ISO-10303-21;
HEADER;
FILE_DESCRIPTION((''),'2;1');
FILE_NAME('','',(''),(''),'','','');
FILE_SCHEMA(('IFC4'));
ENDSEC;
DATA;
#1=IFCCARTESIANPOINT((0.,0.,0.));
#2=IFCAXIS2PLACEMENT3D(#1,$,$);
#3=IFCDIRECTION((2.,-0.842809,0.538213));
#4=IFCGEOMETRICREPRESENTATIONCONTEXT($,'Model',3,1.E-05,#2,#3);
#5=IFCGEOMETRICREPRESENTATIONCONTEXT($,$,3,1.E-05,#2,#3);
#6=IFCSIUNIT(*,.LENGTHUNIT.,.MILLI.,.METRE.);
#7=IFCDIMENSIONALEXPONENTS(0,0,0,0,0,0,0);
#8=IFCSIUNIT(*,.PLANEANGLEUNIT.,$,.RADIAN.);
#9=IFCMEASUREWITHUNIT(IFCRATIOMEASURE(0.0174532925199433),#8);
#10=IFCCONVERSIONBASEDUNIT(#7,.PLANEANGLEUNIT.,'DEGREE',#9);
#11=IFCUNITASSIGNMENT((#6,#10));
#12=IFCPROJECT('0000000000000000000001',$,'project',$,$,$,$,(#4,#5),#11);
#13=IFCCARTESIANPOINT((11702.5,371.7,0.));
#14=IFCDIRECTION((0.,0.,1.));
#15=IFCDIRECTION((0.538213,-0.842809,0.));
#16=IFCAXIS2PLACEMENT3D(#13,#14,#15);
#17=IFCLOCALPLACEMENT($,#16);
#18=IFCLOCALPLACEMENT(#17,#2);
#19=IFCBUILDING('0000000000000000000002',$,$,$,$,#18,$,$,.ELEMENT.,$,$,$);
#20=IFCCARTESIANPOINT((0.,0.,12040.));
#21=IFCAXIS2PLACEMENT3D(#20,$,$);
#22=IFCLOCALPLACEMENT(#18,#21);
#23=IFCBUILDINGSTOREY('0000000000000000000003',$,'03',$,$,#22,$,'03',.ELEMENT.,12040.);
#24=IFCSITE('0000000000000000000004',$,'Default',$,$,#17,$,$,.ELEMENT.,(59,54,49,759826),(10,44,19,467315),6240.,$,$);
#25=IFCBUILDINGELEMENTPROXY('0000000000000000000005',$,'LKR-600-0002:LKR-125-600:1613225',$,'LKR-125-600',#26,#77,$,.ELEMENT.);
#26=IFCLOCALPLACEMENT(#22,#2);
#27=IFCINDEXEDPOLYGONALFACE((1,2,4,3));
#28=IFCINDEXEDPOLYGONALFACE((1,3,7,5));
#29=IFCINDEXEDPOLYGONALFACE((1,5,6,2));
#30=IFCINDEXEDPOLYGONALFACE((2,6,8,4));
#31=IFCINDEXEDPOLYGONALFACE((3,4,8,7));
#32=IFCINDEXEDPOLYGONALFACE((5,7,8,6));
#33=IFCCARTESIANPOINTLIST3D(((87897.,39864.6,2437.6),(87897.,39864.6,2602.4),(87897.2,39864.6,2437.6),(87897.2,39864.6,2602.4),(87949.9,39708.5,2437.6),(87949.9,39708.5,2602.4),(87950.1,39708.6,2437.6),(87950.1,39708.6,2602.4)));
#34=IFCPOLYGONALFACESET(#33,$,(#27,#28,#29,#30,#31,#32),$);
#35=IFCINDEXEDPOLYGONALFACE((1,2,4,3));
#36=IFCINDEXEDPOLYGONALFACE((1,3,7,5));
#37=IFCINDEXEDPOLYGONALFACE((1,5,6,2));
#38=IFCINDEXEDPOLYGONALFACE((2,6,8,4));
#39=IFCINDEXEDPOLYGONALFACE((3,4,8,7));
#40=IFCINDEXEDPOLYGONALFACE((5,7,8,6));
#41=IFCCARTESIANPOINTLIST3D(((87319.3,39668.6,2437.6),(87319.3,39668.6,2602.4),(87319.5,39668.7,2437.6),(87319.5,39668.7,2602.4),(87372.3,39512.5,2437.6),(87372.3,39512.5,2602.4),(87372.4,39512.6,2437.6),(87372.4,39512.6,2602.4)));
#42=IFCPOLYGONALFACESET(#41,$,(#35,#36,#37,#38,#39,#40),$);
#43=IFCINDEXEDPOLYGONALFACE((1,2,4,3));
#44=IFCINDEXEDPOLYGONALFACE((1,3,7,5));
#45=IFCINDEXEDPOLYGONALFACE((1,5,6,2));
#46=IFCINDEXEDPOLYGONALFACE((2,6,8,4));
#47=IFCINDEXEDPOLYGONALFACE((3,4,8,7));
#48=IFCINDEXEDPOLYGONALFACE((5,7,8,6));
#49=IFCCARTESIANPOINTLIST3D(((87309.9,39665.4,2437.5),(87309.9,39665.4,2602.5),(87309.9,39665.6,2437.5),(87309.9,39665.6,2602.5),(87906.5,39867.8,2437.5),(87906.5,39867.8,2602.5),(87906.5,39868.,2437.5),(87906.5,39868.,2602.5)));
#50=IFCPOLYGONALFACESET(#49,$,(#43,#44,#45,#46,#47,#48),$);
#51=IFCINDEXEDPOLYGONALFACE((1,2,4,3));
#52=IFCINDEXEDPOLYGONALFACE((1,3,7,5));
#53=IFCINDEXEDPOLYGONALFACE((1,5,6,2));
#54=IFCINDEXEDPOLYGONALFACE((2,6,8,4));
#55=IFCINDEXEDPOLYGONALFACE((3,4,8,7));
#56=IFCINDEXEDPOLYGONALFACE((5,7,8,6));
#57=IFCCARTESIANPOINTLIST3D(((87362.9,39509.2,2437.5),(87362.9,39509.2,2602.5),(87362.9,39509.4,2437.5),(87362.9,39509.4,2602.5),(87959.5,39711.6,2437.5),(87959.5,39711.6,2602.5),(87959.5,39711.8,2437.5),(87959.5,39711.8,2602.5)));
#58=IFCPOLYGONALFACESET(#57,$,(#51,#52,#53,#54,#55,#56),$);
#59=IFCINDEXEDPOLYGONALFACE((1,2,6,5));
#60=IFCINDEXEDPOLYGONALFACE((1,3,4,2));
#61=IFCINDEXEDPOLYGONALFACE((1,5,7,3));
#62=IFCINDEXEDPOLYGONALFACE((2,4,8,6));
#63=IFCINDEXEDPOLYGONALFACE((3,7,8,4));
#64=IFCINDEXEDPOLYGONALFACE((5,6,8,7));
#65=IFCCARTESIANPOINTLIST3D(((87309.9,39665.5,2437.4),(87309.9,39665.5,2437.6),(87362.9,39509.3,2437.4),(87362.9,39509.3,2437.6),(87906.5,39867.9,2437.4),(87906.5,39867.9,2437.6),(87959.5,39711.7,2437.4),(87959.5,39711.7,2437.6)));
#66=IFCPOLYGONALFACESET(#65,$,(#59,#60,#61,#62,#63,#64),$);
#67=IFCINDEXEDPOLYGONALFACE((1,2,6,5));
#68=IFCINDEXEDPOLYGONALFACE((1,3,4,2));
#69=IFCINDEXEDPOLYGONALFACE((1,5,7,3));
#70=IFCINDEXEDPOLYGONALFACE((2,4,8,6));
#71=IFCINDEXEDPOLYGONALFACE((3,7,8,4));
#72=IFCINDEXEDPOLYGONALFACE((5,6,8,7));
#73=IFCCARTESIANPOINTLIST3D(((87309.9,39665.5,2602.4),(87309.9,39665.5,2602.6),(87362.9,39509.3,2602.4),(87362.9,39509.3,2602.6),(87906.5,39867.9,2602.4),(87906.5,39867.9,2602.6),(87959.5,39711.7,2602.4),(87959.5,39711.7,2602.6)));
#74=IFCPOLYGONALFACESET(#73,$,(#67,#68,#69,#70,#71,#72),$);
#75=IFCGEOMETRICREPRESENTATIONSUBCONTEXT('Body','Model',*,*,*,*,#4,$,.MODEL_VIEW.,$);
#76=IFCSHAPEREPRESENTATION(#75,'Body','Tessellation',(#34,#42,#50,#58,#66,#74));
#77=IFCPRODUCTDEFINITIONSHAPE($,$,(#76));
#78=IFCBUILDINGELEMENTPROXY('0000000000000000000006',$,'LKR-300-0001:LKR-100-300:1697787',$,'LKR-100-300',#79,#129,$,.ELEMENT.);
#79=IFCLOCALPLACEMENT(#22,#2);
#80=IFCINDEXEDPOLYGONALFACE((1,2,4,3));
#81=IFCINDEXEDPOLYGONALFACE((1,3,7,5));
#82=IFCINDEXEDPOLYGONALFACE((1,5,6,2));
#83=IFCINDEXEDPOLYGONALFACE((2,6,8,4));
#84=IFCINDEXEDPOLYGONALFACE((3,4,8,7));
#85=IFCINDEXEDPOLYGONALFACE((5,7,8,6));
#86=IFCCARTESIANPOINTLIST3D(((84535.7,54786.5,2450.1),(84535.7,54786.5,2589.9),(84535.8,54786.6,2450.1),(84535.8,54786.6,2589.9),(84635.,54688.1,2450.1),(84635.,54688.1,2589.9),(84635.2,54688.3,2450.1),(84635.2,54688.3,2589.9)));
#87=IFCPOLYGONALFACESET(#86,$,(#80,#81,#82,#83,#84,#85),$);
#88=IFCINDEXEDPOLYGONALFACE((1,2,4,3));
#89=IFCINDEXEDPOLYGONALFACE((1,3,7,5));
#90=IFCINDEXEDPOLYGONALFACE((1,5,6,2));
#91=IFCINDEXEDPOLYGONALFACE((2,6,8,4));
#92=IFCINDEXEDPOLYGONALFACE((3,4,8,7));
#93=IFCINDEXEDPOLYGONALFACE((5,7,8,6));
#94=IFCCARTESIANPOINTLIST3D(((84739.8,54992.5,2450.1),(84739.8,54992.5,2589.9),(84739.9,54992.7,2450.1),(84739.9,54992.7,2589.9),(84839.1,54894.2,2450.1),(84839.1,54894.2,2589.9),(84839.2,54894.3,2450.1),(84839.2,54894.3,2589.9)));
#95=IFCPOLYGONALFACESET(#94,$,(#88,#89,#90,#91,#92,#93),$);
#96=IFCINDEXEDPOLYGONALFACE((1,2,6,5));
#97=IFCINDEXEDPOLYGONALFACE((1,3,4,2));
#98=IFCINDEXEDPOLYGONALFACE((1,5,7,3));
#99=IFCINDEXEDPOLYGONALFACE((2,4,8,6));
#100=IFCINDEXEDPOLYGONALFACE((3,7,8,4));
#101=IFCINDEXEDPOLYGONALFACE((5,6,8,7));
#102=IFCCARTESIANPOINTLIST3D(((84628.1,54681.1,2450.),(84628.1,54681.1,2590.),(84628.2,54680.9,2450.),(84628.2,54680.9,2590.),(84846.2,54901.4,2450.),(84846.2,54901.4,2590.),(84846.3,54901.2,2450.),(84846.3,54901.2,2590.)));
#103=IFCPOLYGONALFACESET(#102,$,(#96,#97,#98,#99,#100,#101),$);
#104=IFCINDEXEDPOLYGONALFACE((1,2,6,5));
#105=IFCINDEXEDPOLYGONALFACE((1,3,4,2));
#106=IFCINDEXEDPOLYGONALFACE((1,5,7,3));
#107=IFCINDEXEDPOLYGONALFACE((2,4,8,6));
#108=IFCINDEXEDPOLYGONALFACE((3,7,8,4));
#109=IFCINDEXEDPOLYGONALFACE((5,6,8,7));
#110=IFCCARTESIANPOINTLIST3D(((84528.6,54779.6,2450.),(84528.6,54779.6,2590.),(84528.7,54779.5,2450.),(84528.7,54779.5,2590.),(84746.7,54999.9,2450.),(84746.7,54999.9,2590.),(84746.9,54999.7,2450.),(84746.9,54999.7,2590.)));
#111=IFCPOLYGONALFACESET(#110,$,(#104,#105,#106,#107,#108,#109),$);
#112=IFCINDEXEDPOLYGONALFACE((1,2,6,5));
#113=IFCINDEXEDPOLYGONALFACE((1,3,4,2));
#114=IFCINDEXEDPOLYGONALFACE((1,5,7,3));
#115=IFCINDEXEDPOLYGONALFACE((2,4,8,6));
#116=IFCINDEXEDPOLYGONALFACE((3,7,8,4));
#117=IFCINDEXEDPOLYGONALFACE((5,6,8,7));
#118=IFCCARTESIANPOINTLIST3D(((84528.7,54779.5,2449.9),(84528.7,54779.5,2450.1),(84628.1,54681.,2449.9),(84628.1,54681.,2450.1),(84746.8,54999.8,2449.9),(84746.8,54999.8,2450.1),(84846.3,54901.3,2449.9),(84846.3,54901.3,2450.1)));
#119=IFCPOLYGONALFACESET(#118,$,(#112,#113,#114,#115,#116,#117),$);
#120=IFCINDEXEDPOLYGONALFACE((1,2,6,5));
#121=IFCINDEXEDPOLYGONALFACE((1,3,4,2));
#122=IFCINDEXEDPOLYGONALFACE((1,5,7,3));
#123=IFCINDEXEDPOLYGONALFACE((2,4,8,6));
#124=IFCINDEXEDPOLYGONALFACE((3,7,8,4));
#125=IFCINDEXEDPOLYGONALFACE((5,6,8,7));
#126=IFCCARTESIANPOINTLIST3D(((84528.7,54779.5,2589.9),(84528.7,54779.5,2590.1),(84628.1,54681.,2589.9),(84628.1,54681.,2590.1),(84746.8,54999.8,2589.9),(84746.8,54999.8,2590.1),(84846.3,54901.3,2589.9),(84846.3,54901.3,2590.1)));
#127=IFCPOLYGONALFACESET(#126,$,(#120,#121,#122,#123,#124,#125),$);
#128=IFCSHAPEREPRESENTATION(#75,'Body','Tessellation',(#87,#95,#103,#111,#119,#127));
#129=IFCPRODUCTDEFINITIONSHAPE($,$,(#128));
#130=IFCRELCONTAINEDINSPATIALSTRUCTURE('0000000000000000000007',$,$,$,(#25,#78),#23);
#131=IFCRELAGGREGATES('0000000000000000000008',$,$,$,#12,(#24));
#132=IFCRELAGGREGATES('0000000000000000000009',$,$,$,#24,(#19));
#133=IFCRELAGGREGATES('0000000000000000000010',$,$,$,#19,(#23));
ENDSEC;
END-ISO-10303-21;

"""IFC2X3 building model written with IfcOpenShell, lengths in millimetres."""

from ifc_helpers import new_model, entity, si_unit, converted_unit, direction, frame, frame_2d, origin, origin_2d_with_axis, place, context, subcontext, project, spatial, rectangle, extrude, source, transform, mapped, element, save


model = new_model("IFC2X3")

# Units and contexts
model_context = context("Model", 3, precision=1e-05, world=origin(), true_north=direction((2.0, -0.842809, 0.538213)))
context_of_model = context(None, 3, precision=1e-05, world=origin(), true_north=direction((2.0, -0.842809, 0.538213)))
body_context = subcontext(model_context, "Body", "Model", "MODEL_VIEW")
ifc_project = project(units=[si_unit("LENGTHUNIT", "METRE", prefix="MILLI"), converted_unit("PLANEANGLEUNIT", "DEGREE", entity("IfcRatioMeasure", 0.0174532925199433), si_unit("PLANEANGLEUNIT", "RADIAN"), dimensions=[0, 0, 0, 0, 0, 0, 0])], contexts=[model_context, context_of_model])

# Site, building, storey
site_placement = place(None, frame((11702.5, 371.7, 0.0), z_axis=(0.0, 0.0, 1.0), x_axis=(0.538213, -0.842809, 0.0)))
site = spatial("IfcSite", under=ifc_project, at=site_placement, Name="Default", CompositionType="ELEMENT", RefLatitude=(59, 54, 49, 759826), RefLongitude=(10, 44, 19, 467315), RefElevation=6240.0)
building_placement = place(site_placement, origin())
building = spatial("IfcBuilding", under=site, at=building_placement, CompositionType="ELEMENT")
storey_placement = place(building_placement, frame((0.0, 0.0, 12040.0)))
storey = spatial("IfcBuildingStorey", under=building, at=storey_placement, Name="03", LongName="03", CompositionType="ELEMENT", Elevation=12040.0)

# Building element proxies
shared_shape_1 = source(origin(), body_context, "Body", "SweptSolid", [
    extrude(rectangle(XDim=0.2, YDim=164.8, at=frame_2d((0.0, 0.0), x_axis=(1.0, 0.0))), frame((305.0, 0.0, -82.4)), (0.0, 0.0, 1.0), 164.8),
    extrude(rectangle(XDim=0.2, YDim=164.8, at=frame_2d((0.0, 0.0), x_axis=(1.0, 0.0))), frame((-305.0, 0.0, -82.4)), (0.0, 0.0, 1.0), 164.8),
    extrude(rectangle(XDim=0.2, YDim=630.0, at=frame_2d((0.0, 0.0), x_axis=(1.0, 0.0))), frame((0.0, 82.5, -82.5), z_axis=(0.0, 0.0, 1.0), x_axis=(0.0, 1.0, 0.0)), (0.0, 0.0, 1.0), 165.0),
    extrude(rectangle(XDim=0.2, YDim=630.0, at=frame_2d((0.0, 0.0), x_axis=(1.0, 0.0))), frame((0.0, -82.5, -82.5), z_axis=(0.0, 0.0, 1.0), x_axis=(0.0, 1.0, 0.0)), (0.0, 0.0, 1.0), 165.0),
    extrude(rectangle(XDim=165.0, YDim=630.0, at=frame_2d((0.0, 0.0), x_axis=(1.0, 0.0))), frame((0.0, 0.0, -82.6), z_axis=(0.0, 0.0, 1.0), x_axis=(0.0, -1.0, 0.0)), (0.0, 0.0, 1.0), 0.2),
    extrude(rectangle(XDim=165.0, YDim=630.0, at=frame_2d((0.0, 0.0), x_axis=(1.0, 0.0))), frame((0.0, 0.0, 82.4), z_axis=(0.0, 0.0, 1.0), x_axis=(0.0, -1.0, 0.0)), (0.0, 0.0, 1.0), 0.2),
])
for number, where, z_axis, x_axis, name in (
    (1, (87634.7, 39688.6, 2520.0), (0.0, 0.0, 1.0), (0.946986, 0.321274, 0.0), "LKR-600-0002:LKR-125-600:1613225"),
):
    element("IfcBuildingElementProxy", number, at=place(storey_placement, frame(where, z_axis=z_axis, x_axis=x_axis)), inside=storey, Name=name, ObjectType="LKR-125-600", CompositionType="ELEMENT", context=body_context, shape_type="MappedRepresentation", body=[
        mapped(shared_shape_1, transform((0.0, 0.0, 0.0), scale=1.0)),
    ])
shared_shape_2 = source(origin(), body_context, "Body", "SweptSolid", [
    extrude(rectangle(XDim=0.2, YDim=139.8, at=frame_2d((0.0, 0.0), x_axis=(1.0, 0.0))), frame((145.0, 0.0, -69.9)), (0.0, 0.0, 1.0), 139.8),
    extrude(rectangle(XDim=0.2, YDim=139.8, at=frame_2d((0.0, 0.0), x_axis=(1.0, 0.0))), frame((-145.0, 0.0, -69.9)), (0.0, 0.0, 1.0), 139.8),
    extrude(rectangle(XDim=0.2, YDim=310.0, at=frame_2d((0.0, 0.0), x_axis=(1.0, 0.0))), frame((0.0, 70.0, -70.0), z_axis=(0.0, 0.0, 1.0), x_axis=(0.0, 1.0, 0.0)), (0.0, 0.0, 1.0), 140.0),
    extrude(rectangle(XDim=0.2, YDim=310.0, at=frame_2d((0.0, 0.0), x_axis=(1.0, 0.0))), frame((0.0, -70.0, -70.0), z_axis=(0.0, 0.0, 1.0), x_axis=(0.0, 1.0, 0.0)), (0.0, 0.0, 1.0), 140.0),
    extrude(rectangle(XDim=140.0, YDim=310.0, at=origin_2d_with_axis()), frame((0.0, 0.0, -70.1), z_axis=(0.0, 0.0, 1.0), x_axis=(0.0, -1.0, 0.0)), (0.0, 0.0, 1.0), 0.2),
    extrude(rectangle(XDim=140.0, YDim=310.0, at=origin_2d_with_axis()), frame((0.0, 0.0, 69.9), z_axis=(0.0, 0.0, 1.0), x_axis=(0.0, -1.0, 0.0)), (0.0, 0.0, 1.0), 0.2),
])
proxy_placement = place(storey_placement, frame((84687.5, 54840.4, 2520.0), z_axis=(0.0, 0.0, 1.0), x_axis=(-0.703669, -0.710528, 0.0)))
element("IfcBuildingElementProxy", 2, at=proxy_placement, inside=storey, Name="LKR-300-0001:LKR-100-300:1697787", ObjectType="LKR-100-300", CompositionType="ELEMENT", context=body_context, shape_type="MappedRepresentation", body=[
    mapped(shared_shape_2, transform((0.0, 0.0, 0.0), scale=1.0)),
])

save(model, "model.ifc")
